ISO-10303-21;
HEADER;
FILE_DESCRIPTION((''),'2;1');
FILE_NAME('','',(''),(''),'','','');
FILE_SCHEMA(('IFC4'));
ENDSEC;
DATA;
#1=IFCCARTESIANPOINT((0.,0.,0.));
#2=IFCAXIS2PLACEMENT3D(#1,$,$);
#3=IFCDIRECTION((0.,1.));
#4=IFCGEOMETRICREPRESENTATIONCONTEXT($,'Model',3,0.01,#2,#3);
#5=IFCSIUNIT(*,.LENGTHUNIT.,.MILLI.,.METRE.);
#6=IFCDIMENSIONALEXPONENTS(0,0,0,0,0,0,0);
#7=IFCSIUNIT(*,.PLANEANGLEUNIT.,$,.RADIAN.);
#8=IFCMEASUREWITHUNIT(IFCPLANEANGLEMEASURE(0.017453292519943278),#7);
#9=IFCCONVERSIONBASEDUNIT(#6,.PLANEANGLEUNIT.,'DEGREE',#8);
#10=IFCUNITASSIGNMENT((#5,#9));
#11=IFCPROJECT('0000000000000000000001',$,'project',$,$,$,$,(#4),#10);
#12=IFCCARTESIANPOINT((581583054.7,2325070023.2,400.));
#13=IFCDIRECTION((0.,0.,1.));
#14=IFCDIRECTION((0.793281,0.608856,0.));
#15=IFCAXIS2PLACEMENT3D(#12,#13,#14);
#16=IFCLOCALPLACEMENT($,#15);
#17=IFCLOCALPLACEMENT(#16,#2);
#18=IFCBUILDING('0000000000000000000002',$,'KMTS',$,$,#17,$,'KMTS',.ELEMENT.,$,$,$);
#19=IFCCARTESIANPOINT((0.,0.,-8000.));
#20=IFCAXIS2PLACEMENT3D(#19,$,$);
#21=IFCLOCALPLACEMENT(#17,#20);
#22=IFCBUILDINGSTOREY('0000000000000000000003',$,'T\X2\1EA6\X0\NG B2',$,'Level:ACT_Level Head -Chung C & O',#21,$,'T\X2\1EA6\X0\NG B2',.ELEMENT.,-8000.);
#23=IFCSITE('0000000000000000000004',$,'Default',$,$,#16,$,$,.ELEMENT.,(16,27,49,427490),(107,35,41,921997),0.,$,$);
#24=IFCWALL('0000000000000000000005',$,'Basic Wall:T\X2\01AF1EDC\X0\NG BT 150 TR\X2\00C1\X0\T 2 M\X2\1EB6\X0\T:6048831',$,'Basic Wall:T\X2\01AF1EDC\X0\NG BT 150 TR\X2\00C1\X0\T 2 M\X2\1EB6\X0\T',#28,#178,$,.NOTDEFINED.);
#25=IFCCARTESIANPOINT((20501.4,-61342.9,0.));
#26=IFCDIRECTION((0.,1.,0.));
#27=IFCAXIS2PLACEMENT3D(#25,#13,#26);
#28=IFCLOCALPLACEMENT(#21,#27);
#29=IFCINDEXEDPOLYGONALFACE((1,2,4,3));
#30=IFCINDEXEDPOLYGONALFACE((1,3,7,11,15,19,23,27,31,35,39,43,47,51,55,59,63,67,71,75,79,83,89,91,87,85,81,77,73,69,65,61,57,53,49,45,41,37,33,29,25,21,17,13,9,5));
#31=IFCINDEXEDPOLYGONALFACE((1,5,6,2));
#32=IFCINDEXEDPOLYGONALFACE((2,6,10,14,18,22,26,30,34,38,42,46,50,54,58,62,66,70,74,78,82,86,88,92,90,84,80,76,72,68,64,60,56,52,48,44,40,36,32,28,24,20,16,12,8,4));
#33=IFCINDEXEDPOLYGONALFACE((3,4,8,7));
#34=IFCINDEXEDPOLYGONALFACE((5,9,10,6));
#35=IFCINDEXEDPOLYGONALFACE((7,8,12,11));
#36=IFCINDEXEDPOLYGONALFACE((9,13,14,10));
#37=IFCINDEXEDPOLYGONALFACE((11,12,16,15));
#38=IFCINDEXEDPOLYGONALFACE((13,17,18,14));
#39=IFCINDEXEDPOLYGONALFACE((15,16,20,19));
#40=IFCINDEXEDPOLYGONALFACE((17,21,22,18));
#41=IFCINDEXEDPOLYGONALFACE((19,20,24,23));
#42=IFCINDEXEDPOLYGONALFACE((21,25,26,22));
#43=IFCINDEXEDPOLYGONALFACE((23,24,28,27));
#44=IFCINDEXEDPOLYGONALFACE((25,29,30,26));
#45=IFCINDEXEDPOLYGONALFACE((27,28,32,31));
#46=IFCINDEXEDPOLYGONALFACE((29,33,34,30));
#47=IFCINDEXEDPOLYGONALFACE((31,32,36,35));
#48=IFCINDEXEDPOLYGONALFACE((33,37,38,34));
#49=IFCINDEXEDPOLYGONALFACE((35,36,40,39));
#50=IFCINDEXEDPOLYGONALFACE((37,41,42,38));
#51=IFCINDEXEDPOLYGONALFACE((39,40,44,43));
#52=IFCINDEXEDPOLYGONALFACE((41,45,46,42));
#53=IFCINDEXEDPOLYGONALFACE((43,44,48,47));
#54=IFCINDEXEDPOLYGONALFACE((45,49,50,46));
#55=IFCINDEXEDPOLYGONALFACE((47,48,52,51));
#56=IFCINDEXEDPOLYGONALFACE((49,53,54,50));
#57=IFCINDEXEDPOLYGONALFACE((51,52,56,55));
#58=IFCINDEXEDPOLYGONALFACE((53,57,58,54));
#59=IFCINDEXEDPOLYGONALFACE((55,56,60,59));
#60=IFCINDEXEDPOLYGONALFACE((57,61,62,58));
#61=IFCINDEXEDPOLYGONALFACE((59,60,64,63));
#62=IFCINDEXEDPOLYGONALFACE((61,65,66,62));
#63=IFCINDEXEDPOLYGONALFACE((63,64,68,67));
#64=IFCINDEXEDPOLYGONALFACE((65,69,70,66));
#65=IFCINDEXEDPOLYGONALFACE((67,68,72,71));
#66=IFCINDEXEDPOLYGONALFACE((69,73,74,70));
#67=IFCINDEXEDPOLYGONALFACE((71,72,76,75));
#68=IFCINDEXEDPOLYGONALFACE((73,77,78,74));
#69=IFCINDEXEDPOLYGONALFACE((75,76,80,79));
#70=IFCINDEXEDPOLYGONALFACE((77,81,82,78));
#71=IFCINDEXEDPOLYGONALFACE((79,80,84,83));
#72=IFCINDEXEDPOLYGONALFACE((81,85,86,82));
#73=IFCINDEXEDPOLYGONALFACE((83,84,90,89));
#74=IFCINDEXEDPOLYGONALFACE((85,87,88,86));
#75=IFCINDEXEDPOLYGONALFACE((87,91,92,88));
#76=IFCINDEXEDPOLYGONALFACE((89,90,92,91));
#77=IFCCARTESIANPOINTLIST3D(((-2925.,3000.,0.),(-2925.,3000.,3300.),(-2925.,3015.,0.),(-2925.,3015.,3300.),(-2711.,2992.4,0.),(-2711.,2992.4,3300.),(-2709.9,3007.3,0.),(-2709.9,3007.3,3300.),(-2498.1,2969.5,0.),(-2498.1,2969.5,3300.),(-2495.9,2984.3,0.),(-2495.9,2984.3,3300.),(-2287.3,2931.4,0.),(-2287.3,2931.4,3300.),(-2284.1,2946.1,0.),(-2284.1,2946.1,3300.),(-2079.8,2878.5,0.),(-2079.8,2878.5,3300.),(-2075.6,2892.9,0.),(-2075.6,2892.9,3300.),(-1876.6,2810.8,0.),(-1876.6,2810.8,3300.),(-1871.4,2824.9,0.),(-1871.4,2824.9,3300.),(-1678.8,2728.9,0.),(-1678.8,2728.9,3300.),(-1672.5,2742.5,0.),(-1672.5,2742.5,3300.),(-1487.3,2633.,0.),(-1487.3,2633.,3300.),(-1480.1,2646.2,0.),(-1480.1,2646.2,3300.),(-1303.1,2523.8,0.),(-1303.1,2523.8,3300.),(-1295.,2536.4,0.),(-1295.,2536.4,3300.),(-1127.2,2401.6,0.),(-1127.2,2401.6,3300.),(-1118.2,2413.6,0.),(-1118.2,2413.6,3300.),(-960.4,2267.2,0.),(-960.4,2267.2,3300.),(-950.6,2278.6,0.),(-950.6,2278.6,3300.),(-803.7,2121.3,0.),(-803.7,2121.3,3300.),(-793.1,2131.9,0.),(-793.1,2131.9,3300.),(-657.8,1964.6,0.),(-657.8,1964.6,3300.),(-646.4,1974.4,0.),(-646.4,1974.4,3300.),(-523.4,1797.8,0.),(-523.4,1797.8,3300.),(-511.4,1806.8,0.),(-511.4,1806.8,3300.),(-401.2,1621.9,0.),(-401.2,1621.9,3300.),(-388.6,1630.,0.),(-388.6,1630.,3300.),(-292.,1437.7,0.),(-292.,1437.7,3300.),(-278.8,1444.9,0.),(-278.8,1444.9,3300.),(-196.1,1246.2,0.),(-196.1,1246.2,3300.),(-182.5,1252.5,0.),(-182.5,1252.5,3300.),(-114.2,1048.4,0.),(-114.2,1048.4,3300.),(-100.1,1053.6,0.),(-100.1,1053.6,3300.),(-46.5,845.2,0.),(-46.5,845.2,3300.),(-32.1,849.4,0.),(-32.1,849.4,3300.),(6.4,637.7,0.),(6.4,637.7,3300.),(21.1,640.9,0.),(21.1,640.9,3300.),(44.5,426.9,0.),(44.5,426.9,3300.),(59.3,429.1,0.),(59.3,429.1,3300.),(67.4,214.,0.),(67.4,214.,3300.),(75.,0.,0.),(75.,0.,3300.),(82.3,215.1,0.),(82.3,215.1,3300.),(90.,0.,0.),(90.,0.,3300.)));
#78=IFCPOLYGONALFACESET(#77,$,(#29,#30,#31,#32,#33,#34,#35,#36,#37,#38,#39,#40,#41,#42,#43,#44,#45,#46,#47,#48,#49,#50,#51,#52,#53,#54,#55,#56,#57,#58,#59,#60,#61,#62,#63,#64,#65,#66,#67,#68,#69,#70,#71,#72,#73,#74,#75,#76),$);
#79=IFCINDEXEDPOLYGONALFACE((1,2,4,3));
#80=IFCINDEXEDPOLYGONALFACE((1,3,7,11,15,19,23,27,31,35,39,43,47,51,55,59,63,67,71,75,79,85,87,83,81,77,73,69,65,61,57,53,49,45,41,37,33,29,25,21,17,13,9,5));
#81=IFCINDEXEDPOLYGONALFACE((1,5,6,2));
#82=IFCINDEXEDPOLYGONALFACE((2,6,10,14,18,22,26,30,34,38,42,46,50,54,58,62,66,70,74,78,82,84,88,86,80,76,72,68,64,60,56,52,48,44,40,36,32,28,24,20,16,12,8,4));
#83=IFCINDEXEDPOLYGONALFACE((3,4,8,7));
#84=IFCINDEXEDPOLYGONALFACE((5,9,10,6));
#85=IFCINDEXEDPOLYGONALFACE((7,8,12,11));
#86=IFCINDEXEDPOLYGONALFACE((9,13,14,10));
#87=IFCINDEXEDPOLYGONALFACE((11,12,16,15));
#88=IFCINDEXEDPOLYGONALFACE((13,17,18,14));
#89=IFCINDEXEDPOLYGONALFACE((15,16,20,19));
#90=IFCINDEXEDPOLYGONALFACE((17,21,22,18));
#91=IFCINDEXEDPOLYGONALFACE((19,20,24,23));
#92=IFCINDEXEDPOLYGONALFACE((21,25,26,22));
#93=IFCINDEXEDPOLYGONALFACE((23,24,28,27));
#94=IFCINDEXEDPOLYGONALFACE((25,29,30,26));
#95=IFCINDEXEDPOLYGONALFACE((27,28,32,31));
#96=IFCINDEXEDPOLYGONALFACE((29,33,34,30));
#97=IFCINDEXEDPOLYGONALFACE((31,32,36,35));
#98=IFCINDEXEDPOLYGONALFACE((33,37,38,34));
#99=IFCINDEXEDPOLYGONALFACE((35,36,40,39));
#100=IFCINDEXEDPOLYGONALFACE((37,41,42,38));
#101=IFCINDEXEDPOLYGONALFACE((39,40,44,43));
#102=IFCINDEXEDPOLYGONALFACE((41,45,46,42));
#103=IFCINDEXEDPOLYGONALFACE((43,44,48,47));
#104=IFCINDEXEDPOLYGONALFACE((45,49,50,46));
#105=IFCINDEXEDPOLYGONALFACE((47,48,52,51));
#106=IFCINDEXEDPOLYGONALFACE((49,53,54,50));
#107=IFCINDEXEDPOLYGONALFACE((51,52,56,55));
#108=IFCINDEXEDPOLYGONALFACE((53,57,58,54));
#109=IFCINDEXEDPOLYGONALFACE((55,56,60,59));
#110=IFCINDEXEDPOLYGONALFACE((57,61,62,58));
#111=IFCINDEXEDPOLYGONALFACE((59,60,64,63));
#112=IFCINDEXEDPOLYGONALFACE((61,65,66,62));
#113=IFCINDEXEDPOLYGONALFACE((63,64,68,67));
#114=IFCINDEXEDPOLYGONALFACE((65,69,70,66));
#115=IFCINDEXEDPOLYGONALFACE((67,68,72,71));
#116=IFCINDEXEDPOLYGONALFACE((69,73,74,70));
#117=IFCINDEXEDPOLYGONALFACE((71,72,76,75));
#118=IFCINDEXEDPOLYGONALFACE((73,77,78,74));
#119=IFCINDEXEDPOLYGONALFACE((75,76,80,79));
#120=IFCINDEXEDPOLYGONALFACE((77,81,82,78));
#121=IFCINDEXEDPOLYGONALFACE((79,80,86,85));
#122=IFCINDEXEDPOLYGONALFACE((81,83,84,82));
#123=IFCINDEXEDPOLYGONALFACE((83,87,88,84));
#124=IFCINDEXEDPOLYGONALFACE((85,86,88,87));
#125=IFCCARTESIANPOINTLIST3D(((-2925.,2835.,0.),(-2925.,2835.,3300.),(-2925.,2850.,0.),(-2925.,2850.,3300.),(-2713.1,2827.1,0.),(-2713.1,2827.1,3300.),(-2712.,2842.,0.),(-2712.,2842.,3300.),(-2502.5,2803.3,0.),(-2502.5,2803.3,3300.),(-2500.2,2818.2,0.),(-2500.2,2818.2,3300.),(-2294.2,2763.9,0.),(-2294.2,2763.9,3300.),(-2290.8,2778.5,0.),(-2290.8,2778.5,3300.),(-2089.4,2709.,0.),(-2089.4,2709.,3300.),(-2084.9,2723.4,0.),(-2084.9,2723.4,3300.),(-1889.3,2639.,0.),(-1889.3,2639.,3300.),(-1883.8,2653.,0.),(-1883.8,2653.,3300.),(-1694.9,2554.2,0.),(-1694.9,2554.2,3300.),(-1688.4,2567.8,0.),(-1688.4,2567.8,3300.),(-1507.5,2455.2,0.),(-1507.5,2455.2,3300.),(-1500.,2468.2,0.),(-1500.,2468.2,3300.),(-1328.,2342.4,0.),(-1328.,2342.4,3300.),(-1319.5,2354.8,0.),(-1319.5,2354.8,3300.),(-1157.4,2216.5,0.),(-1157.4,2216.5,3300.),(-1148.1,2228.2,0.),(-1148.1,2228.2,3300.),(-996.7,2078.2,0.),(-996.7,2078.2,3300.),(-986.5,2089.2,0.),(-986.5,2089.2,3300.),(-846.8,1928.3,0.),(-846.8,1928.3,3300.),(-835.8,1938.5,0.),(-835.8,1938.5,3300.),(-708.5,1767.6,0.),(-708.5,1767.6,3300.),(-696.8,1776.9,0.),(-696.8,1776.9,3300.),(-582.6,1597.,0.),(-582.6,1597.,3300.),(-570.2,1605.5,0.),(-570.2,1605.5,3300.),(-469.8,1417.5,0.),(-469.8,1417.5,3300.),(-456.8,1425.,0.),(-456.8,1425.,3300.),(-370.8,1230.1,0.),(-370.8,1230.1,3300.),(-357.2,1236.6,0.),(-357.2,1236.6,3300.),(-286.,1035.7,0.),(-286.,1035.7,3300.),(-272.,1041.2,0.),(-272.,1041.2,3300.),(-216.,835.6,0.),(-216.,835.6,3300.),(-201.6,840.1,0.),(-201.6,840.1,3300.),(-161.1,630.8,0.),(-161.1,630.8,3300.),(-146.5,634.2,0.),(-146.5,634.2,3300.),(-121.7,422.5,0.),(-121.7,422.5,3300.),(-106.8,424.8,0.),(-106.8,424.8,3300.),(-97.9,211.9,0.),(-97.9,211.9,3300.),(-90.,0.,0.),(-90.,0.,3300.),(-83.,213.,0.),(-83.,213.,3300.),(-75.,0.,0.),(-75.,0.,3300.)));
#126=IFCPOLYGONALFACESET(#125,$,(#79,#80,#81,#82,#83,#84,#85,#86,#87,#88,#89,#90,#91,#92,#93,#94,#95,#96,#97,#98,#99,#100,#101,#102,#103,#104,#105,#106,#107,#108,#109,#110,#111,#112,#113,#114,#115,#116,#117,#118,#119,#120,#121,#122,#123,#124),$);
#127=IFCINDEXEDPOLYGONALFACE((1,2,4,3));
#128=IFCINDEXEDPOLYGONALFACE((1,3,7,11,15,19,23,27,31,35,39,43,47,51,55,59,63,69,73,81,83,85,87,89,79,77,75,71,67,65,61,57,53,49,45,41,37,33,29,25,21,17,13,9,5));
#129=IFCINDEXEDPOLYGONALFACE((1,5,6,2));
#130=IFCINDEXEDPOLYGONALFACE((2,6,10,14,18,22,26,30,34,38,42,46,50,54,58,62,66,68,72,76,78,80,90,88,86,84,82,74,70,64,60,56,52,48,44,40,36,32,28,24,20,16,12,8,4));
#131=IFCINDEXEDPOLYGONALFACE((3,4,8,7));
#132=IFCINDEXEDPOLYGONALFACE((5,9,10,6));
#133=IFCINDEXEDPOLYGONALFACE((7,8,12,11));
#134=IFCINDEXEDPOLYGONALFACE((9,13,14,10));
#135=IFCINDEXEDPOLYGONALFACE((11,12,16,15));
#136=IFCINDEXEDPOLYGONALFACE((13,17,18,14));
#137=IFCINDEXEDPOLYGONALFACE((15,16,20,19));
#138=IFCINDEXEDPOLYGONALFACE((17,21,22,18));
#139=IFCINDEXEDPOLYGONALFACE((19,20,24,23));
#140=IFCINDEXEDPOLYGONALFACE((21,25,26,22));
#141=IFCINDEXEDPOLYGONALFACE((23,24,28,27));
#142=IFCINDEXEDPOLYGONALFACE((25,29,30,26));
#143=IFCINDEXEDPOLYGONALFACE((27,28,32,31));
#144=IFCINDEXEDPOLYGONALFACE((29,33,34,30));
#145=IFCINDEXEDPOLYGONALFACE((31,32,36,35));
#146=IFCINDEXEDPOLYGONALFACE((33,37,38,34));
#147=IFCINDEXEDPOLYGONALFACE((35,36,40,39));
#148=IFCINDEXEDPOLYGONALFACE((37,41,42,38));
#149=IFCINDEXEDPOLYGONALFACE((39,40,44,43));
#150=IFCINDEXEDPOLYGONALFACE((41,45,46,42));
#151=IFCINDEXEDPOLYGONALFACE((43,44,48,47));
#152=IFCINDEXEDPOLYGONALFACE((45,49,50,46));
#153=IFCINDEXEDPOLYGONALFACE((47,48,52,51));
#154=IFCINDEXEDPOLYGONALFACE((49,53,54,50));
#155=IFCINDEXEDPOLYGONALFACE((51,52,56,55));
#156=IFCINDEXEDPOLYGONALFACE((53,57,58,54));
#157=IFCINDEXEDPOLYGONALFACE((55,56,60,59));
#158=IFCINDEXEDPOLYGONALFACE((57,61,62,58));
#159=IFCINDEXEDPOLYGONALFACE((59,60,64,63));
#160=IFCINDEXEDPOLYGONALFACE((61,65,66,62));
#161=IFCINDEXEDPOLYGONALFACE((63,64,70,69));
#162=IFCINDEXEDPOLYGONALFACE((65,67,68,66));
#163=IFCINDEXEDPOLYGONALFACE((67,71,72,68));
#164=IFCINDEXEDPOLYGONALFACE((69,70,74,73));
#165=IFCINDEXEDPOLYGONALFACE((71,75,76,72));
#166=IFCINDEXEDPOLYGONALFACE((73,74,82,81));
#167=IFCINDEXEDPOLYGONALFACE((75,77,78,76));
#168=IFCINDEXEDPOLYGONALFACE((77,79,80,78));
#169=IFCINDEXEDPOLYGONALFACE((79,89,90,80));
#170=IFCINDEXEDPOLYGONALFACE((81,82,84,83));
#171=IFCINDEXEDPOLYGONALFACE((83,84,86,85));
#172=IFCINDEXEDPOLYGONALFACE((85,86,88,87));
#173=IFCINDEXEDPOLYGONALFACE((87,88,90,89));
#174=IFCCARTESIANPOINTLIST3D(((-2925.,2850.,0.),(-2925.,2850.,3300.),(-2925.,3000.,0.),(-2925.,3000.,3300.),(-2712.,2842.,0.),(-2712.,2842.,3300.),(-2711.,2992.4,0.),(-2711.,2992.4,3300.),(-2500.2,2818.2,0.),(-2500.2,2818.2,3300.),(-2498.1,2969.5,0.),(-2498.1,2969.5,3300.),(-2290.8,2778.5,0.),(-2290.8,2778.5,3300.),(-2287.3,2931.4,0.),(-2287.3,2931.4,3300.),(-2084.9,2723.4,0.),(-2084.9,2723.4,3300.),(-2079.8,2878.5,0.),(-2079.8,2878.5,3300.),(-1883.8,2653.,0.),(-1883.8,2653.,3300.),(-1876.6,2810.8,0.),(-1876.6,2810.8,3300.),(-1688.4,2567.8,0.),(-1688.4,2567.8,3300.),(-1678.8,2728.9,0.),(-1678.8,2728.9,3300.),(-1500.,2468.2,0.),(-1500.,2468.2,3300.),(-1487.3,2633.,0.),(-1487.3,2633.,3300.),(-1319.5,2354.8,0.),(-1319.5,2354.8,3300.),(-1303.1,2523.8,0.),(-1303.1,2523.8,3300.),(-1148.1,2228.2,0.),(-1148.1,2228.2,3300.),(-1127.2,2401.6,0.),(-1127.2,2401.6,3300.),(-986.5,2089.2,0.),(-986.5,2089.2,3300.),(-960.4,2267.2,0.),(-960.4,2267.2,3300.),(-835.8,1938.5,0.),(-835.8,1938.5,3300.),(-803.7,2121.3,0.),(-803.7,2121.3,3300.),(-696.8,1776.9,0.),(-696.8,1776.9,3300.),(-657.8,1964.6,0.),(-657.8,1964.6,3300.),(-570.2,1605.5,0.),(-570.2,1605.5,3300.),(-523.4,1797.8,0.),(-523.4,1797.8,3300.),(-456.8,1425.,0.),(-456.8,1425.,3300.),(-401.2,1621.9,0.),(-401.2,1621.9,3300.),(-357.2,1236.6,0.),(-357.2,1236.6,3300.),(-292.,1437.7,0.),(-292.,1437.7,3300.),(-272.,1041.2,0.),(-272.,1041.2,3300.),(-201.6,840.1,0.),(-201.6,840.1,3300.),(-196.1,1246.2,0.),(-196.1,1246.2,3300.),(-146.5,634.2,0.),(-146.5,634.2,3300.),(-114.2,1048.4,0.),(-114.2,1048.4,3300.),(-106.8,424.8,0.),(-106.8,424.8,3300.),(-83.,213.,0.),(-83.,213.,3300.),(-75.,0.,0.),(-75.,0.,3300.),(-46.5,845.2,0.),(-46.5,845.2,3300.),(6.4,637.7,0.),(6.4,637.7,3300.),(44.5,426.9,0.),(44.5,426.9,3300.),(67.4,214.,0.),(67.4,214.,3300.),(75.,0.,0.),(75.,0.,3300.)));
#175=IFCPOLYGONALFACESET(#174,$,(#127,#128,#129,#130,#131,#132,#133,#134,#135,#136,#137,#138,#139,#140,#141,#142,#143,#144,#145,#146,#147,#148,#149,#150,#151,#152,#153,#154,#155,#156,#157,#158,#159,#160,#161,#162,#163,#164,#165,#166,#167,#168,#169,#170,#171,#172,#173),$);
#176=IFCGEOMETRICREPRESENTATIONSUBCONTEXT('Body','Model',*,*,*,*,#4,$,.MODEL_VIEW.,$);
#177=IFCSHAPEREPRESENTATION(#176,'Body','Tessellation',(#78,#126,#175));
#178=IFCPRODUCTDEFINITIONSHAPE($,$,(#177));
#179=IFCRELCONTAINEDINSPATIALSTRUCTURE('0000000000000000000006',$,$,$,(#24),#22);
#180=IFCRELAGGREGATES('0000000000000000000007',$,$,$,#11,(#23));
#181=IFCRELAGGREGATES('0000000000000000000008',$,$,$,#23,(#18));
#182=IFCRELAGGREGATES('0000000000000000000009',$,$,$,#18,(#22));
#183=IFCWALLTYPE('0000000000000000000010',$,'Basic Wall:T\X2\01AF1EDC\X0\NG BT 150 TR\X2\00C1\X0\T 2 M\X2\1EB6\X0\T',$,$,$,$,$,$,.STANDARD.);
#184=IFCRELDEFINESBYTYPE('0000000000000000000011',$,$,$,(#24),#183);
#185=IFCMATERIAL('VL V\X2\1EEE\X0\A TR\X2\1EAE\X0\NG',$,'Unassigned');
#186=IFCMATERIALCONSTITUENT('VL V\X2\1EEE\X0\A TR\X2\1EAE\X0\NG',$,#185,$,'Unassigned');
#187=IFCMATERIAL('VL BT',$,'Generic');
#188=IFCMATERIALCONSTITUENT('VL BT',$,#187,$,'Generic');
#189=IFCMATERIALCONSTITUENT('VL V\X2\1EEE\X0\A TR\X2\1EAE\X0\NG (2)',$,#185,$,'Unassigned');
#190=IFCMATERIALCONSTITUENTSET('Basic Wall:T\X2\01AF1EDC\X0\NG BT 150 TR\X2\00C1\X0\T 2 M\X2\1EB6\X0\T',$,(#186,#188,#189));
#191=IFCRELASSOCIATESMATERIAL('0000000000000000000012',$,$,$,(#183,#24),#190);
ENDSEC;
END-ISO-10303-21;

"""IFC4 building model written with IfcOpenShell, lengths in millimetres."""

from ifc_helpers import new_model, entity, si_unit, converted_unit, direction, frame, origin, place, context, subcontext, project, spatial, line, arc, indexed_curve, outline, extrude, material, constituent, constituent_set, type_object, element, save


model = new_model("IFC4")

# Units and contexts
model_context = context("Model", 3, precision=0.01, world=origin(), true_north=direction((0.0, 1.0)))
body_context = subcontext(model_context, "Body", "Model", "MODEL_VIEW")
ifc_project = project(units=[si_unit("LENGTHUNIT", "METRE", prefix="MILLI"), converted_unit("PLANEANGLEUNIT", "DEGREE", entity("IfcPlaneAngleMeasure", 0.017453292519943278), si_unit("PLANEANGLEUNIT", "RADIAN"), dimensions=[0, 0, 0, 0, 0, 0, 0])], contexts=[model_context])

# Site, building, storey
site_placement = place(None, frame((581583054.7, 2325070023.2, 400.0), z_axis=(0.0, 0.0, 1.0), x_axis=(0.793281, 0.608856, 0.0)))
site = spatial("IfcSite", under=ifc_project, at=site_placement, Name="Default", CompositionType="ELEMENT", RefLatitude=(16, 27, 49, 427490), RefLongitude=(107, 35, 41, 921997), RefElevation=0.0)
building_placement = place(site_placement, origin())
building = spatial("IfcBuilding", under=site, at=building_placement, Name="KMTS", LongName="KMTS", CompositionType="ELEMENT")
storey_placement = place(building_placement, frame((0.0, 0.0, -8000.0)))
storey = spatial("IfcBuildingStorey", under=building, at=storey_placement, Name="TẦNG B2", ObjectType="Level:ACT_Level Head -Chung C & O", LongName="TẦNG B2", CompositionType="ELEMENT", Elevation=-8000.0)

# Shared definitions
ifc_material_1 = material(Name="VL VỮA TRẮNG", Category="Unassigned")
ifc_constituent_1 = constituent(ifc_material_1, Name="VL VỮA TRẮNG", Category="Unassigned")
ifc_material_2 = material(Name="VL BT", Category="Generic")
ifc_constituent_2 = constituent(ifc_material_2, Name="VL BT", Category="Generic")
ifc_constituent_3 = constituent(ifc_material_1, Name="VL VỮA TRẮNG (2)", Category="Unassigned")
ifc_constituent_set_1 = constituent_set(constituents=[ifc_constituent_1, ifc_constituent_2, ifc_constituent_3], Name="Basic Wall:TƯỜNG BT 150 TRÁT 2 MẶT")
wall_type_1 = type_object("IfcWallType", Name="Basic Wall:TƯỜNG BT 150 TRÁT 2 MẶT", PredefinedType="STANDARD", material=ifc_constituent_set_1)

# Wall
wall_1_placement = place(storey_placement, frame((20501.4, -61342.9, 0.0), z_axis=(0.0, 0.0, 1.0), x_axis=(0.0, 1.0, 0.0)))
element("IfcWall", 1, at=wall_1_placement, inside=storey, type_object=wall_type_1, material=ifc_constituent_set_1, Name="Basic Wall:TƯỜNG BT 150 TRÁT 2 MẶT:6048831", ObjectType="Basic Wall:TƯỜNG BT 150 TRÁT 2 MẶT", PredefinedType="NOTDEFINED", context=body_context, shape_type="SweptSolid", body=[
    extrude(outline(indexed_curve([(-1511.3, -1503.7), (-1496.3, -1503.8), (-617.6, 617.6), (1503.7, 1496.3), (1503.8, 1511.3), (-628.2, 628.2)], segments=[line(1, 2), arc(2, 3, 4), line(4, 5), arc(5, 6, 1)], self_intersect=False)), frame((-1421.3, 1503.8, 0.0), z_axis=(0.0, 0.0, 1.0), x_axis=(0.0, -1.0, 0.0)), (0.0, 0.0, 1.0), 3300.0),
    extrude(outline(indexed_curve([(1413.8, 1421.2), (583.4, -583.4), (-1421.3, -1413.7), (-1421.3, -1428.7), (594.0, -594.0), (1428.8, 1421.2)], segments=[arc(1, 2, 3), line(3, 4), arc(4, 5, 6), line(6, 1)], self_intersect=False)), frame((-1503.8, 1421.3, 0.0), z_axis=(0.0, 0.0, -1.0), x_axis=(1.0, 0.0, 0.0)), (0.0, 0.0, -1.0), 3300.0),
    extrude(outline(indexed_curve([(-1476.9, -1372.2), (-1478.4, -1522.2), (651.9, -665.6), (1552.7, 1446.4), (1402.7, 1448.0), (547.0, -558.5)], segments=[line(1, 2), arc(2, 3, 4), line(4, 5), arc(5, 6, 1)], self_intersect=False)), frame((-1462.5, 1462.5, 0.0), z_axis=(0.0, 0.0, -1.0), x_axis=(0.999946, -0.010416, 0.0)), (0.0, 0.0, -1.0), 3300.0),
])

save(model, "model.ifc")
